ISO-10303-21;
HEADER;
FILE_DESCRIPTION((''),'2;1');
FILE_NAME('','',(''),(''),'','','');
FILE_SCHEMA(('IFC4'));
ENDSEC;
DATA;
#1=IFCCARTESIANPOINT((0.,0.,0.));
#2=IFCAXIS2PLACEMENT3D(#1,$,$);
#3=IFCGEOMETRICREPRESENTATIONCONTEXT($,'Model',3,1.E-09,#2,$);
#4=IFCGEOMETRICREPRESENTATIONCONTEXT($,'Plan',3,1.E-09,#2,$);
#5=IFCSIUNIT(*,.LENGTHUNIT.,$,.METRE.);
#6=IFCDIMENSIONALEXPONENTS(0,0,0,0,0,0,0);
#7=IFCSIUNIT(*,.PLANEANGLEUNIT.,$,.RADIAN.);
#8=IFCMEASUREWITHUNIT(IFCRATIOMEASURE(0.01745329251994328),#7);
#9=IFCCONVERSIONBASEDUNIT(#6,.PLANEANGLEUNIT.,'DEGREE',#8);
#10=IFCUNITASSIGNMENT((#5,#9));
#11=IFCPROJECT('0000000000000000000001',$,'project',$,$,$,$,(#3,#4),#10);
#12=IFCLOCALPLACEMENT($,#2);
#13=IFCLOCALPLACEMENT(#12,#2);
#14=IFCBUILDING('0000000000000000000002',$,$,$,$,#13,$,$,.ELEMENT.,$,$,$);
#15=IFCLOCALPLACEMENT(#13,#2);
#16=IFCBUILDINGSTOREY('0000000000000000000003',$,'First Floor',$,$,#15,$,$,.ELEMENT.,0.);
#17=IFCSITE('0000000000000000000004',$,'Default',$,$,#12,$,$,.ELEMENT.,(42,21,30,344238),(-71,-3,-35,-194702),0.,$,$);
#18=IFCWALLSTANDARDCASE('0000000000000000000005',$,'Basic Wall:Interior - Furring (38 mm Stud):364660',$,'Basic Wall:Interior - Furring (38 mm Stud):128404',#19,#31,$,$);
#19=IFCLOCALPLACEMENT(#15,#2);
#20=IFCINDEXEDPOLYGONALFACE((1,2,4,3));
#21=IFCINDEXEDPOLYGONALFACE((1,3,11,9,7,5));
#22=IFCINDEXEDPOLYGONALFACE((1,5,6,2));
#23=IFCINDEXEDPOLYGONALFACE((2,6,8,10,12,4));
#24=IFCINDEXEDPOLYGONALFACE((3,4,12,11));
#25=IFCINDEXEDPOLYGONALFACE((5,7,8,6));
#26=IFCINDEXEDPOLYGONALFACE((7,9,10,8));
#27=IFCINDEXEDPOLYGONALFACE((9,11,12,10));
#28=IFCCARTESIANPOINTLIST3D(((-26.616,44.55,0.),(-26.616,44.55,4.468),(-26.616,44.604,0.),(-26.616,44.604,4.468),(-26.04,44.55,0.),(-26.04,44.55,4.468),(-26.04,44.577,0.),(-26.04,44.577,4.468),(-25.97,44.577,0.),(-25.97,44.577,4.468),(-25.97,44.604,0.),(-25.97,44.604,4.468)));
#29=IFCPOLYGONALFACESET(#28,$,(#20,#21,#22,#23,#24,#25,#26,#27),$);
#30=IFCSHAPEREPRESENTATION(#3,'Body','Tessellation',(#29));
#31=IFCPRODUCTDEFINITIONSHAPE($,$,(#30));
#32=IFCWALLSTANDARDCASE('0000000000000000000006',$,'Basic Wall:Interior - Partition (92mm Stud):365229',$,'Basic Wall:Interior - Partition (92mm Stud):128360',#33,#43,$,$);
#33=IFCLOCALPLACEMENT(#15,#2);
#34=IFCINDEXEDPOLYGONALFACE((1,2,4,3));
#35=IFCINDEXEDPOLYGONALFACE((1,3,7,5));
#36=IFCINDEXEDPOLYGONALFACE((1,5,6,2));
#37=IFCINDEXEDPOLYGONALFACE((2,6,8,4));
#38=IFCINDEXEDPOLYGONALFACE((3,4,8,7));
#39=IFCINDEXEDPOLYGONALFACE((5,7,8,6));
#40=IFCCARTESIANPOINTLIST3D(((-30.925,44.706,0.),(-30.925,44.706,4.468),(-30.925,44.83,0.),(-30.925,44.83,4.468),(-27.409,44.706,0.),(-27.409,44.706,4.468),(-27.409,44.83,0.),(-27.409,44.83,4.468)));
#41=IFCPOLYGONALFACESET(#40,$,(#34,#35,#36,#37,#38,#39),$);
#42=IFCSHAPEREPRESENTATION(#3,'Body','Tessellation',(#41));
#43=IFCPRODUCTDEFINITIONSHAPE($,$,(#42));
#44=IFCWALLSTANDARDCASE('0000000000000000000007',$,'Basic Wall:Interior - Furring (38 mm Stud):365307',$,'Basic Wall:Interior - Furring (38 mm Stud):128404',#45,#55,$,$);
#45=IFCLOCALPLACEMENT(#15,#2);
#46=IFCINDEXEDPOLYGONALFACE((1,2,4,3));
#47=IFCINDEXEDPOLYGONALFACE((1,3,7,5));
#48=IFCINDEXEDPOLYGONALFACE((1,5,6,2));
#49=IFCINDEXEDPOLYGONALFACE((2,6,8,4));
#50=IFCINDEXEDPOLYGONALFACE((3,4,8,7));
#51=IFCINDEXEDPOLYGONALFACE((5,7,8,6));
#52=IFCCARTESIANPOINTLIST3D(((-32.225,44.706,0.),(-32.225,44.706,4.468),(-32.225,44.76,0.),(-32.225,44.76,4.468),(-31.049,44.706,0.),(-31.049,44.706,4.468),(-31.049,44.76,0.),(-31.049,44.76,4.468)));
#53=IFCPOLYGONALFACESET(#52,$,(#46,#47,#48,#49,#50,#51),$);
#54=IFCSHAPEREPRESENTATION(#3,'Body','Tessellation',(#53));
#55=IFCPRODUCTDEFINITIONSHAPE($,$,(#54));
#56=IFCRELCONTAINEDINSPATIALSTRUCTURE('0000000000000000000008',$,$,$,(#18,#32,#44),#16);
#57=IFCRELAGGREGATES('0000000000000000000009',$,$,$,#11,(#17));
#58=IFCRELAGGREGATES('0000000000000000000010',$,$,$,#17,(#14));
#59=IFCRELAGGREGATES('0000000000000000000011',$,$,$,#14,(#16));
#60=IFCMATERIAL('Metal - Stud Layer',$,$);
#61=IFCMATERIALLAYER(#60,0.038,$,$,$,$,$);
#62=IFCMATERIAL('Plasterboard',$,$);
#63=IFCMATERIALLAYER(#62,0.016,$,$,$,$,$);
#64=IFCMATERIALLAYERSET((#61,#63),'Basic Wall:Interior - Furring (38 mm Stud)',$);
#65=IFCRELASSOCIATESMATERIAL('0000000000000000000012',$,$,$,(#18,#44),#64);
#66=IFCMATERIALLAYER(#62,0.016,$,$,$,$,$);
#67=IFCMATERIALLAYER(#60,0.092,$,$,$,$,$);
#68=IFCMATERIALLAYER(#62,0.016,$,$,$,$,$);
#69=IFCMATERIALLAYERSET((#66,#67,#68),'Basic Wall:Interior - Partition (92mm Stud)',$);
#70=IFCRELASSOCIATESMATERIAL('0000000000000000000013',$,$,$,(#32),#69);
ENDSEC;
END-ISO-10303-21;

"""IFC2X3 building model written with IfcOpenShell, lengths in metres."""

from ifc_helpers import new_model, entity, si_unit, converted_unit, frame, frame_2d, origin, place, context, project, spatial, polyline, rectangle, outline, extrude, material, layer, layer_set, layer_usage, element, save


model = new_model("IFC2X3")

# Units and contexts
model_context = context("Model", 3, precision=1e-09, world=origin())
plan_context = context("Plan", 3, precision=1e-09, world=origin())
ifc_project = project(units=[si_unit("LENGTHUNIT", "METRE"), converted_unit("PLANEANGLEUNIT", "DEGREE", entity("IfcRatioMeasure", 0.01745329251994328), si_unit("PLANEANGLEUNIT", "RADIAN"), dimensions=[0, 0, 0, 0, 0, 0, 0])], contexts=[model_context, plan_context])

# Site, building, storey
site_placement = place(None, origin())
site = spatial("IfcSite", under=ifc_project, at=site_placement, Name="Default", CompositionType="ELEMENT", RefLatitude=(42, 21, 30, 344238), RefLongitude=(-71, -3, -35, -194702), RefElevation=0.0)
building_placement = place(site_placement, origin())
building = spatial("IfcBuilding", under=site, at=building_placement, CompositionType="ELEMENT")
storey_placement = place(building_placement, origin())
storey = spatial("IfcBuildingStorey", under=building, at=storey_placement, Name="First Floor", CompositionType="ELEMENT", Elevation=0.0)

# Shared definitions
ifc_material_1 = material(Name="Plasterboard")
ifc_layer_1 = layer(ifc_material_1, 0.016)
ifc_material_2 = material(Name="Metal - Stud Layer")
ifc_layer_2 = layer(ifc_material_2, 0.092)
ifc_layer_3 = layer(ifc_material_1, 0.016)
ifc_layer_set_1 = layer_set([ifc_layer_1, ifc_layer_2, ifc_layer_3], Name="Basic Wall:Interior - Partition (92mm Stud)")

# Walls
ifc_layer_4 = layer(ifc_material_2, 0.038)
ifc_layer_5 = layer(ifc_material_1, 0.016)
ifc_layer_set_2 = layer_set([ifc_layer_4, ifc_layer_5], Name="Basic Wall:Interior - Furring (38 mm Stud)")
ifc_layer_usage_1 = layer_usage(ifc_layer_set_2, "AXIS2", "NEGATIVE", 0.027)
wall_1_placement = place(storey_placement, frame((-26.616, 44.577, 0.0)))
element("IfcWallStandardCase", 1, at=wall_1_placement, inside=storey, material=ifc_layer_usage_1, Name="Basic Wall:Interior - Furring (38 mm Stud):364660", ObjectType="Basic Wall:Interior - Furring (38 mm Stud):128404", context=model_context, shape_type="SweptSolid", body=[
    extrude(outline(polyline([(0.576, -0.027), (0.576, 0.0), (0.646, 0.0), (0.646, 0.027), (0.0, 0.027), (0.0, -0.027), (0.576, -0.027)])), origin(), (0.0, 0.0, 1.0), 4.468),
])
ifc_layer_usage_2 = layer_usage(ifc_layer_set_1, "AXIS2", "NEGATIVE", 0.062)
wall_2_placement = place(storey_placement, frame((-30.925, 44.768, 0.0)))
element("IfcWallStandardCase", 2, at=wall_2_placement, inside=storey, material=ifc_layer_usage_2, Name="Basic Wall:Interior - Partition (92mm Stud):365229", ObjectType="Basic Wall:Interior - Partition (92mm Stud):128360", context=model_context, shape_type="SweptSolid", body=[
    extrude(rectangle(XDim=3.516, YDim=0.124, at=frame_2d((1.758, 0.0), x_axis=(-1.0, 0.0))), origin(), (0.0, 0.0, 1.0), 4.468),
])
ifc_layer_usage_3 = layer_usage(ifc_layer_set_2, "AXIS2", "POSITIVE", -0.027)
wall_3_placement = place(storey_placement, frame((-31.049, 44.733, 0.0), z_axis=(0.0, 0.0, 1.0), x_axis=(-1.0, 0.0, 0.0)))
element("IfcWallStandardCase", 3, at=wall_3_placement, inside=storey, material=ifc_layer_usage_3, Name="Basic Wall:Interior - Furring (38 mm Stud):365307", ObjectType="Basic Wall:Interior - Furring (38 mm Stud):128404", context=model_context, shape_type="SweptSolid", body=[
    extrude(rectangle(XDim=1.176, YDim=0.054, at=frame_2d((0.588, 0.0), x_axis=(-1.0, 0.0))), origin(), (0.0, 0.0, 1.0), 4.468),
])

save(model, "model.ifc")
